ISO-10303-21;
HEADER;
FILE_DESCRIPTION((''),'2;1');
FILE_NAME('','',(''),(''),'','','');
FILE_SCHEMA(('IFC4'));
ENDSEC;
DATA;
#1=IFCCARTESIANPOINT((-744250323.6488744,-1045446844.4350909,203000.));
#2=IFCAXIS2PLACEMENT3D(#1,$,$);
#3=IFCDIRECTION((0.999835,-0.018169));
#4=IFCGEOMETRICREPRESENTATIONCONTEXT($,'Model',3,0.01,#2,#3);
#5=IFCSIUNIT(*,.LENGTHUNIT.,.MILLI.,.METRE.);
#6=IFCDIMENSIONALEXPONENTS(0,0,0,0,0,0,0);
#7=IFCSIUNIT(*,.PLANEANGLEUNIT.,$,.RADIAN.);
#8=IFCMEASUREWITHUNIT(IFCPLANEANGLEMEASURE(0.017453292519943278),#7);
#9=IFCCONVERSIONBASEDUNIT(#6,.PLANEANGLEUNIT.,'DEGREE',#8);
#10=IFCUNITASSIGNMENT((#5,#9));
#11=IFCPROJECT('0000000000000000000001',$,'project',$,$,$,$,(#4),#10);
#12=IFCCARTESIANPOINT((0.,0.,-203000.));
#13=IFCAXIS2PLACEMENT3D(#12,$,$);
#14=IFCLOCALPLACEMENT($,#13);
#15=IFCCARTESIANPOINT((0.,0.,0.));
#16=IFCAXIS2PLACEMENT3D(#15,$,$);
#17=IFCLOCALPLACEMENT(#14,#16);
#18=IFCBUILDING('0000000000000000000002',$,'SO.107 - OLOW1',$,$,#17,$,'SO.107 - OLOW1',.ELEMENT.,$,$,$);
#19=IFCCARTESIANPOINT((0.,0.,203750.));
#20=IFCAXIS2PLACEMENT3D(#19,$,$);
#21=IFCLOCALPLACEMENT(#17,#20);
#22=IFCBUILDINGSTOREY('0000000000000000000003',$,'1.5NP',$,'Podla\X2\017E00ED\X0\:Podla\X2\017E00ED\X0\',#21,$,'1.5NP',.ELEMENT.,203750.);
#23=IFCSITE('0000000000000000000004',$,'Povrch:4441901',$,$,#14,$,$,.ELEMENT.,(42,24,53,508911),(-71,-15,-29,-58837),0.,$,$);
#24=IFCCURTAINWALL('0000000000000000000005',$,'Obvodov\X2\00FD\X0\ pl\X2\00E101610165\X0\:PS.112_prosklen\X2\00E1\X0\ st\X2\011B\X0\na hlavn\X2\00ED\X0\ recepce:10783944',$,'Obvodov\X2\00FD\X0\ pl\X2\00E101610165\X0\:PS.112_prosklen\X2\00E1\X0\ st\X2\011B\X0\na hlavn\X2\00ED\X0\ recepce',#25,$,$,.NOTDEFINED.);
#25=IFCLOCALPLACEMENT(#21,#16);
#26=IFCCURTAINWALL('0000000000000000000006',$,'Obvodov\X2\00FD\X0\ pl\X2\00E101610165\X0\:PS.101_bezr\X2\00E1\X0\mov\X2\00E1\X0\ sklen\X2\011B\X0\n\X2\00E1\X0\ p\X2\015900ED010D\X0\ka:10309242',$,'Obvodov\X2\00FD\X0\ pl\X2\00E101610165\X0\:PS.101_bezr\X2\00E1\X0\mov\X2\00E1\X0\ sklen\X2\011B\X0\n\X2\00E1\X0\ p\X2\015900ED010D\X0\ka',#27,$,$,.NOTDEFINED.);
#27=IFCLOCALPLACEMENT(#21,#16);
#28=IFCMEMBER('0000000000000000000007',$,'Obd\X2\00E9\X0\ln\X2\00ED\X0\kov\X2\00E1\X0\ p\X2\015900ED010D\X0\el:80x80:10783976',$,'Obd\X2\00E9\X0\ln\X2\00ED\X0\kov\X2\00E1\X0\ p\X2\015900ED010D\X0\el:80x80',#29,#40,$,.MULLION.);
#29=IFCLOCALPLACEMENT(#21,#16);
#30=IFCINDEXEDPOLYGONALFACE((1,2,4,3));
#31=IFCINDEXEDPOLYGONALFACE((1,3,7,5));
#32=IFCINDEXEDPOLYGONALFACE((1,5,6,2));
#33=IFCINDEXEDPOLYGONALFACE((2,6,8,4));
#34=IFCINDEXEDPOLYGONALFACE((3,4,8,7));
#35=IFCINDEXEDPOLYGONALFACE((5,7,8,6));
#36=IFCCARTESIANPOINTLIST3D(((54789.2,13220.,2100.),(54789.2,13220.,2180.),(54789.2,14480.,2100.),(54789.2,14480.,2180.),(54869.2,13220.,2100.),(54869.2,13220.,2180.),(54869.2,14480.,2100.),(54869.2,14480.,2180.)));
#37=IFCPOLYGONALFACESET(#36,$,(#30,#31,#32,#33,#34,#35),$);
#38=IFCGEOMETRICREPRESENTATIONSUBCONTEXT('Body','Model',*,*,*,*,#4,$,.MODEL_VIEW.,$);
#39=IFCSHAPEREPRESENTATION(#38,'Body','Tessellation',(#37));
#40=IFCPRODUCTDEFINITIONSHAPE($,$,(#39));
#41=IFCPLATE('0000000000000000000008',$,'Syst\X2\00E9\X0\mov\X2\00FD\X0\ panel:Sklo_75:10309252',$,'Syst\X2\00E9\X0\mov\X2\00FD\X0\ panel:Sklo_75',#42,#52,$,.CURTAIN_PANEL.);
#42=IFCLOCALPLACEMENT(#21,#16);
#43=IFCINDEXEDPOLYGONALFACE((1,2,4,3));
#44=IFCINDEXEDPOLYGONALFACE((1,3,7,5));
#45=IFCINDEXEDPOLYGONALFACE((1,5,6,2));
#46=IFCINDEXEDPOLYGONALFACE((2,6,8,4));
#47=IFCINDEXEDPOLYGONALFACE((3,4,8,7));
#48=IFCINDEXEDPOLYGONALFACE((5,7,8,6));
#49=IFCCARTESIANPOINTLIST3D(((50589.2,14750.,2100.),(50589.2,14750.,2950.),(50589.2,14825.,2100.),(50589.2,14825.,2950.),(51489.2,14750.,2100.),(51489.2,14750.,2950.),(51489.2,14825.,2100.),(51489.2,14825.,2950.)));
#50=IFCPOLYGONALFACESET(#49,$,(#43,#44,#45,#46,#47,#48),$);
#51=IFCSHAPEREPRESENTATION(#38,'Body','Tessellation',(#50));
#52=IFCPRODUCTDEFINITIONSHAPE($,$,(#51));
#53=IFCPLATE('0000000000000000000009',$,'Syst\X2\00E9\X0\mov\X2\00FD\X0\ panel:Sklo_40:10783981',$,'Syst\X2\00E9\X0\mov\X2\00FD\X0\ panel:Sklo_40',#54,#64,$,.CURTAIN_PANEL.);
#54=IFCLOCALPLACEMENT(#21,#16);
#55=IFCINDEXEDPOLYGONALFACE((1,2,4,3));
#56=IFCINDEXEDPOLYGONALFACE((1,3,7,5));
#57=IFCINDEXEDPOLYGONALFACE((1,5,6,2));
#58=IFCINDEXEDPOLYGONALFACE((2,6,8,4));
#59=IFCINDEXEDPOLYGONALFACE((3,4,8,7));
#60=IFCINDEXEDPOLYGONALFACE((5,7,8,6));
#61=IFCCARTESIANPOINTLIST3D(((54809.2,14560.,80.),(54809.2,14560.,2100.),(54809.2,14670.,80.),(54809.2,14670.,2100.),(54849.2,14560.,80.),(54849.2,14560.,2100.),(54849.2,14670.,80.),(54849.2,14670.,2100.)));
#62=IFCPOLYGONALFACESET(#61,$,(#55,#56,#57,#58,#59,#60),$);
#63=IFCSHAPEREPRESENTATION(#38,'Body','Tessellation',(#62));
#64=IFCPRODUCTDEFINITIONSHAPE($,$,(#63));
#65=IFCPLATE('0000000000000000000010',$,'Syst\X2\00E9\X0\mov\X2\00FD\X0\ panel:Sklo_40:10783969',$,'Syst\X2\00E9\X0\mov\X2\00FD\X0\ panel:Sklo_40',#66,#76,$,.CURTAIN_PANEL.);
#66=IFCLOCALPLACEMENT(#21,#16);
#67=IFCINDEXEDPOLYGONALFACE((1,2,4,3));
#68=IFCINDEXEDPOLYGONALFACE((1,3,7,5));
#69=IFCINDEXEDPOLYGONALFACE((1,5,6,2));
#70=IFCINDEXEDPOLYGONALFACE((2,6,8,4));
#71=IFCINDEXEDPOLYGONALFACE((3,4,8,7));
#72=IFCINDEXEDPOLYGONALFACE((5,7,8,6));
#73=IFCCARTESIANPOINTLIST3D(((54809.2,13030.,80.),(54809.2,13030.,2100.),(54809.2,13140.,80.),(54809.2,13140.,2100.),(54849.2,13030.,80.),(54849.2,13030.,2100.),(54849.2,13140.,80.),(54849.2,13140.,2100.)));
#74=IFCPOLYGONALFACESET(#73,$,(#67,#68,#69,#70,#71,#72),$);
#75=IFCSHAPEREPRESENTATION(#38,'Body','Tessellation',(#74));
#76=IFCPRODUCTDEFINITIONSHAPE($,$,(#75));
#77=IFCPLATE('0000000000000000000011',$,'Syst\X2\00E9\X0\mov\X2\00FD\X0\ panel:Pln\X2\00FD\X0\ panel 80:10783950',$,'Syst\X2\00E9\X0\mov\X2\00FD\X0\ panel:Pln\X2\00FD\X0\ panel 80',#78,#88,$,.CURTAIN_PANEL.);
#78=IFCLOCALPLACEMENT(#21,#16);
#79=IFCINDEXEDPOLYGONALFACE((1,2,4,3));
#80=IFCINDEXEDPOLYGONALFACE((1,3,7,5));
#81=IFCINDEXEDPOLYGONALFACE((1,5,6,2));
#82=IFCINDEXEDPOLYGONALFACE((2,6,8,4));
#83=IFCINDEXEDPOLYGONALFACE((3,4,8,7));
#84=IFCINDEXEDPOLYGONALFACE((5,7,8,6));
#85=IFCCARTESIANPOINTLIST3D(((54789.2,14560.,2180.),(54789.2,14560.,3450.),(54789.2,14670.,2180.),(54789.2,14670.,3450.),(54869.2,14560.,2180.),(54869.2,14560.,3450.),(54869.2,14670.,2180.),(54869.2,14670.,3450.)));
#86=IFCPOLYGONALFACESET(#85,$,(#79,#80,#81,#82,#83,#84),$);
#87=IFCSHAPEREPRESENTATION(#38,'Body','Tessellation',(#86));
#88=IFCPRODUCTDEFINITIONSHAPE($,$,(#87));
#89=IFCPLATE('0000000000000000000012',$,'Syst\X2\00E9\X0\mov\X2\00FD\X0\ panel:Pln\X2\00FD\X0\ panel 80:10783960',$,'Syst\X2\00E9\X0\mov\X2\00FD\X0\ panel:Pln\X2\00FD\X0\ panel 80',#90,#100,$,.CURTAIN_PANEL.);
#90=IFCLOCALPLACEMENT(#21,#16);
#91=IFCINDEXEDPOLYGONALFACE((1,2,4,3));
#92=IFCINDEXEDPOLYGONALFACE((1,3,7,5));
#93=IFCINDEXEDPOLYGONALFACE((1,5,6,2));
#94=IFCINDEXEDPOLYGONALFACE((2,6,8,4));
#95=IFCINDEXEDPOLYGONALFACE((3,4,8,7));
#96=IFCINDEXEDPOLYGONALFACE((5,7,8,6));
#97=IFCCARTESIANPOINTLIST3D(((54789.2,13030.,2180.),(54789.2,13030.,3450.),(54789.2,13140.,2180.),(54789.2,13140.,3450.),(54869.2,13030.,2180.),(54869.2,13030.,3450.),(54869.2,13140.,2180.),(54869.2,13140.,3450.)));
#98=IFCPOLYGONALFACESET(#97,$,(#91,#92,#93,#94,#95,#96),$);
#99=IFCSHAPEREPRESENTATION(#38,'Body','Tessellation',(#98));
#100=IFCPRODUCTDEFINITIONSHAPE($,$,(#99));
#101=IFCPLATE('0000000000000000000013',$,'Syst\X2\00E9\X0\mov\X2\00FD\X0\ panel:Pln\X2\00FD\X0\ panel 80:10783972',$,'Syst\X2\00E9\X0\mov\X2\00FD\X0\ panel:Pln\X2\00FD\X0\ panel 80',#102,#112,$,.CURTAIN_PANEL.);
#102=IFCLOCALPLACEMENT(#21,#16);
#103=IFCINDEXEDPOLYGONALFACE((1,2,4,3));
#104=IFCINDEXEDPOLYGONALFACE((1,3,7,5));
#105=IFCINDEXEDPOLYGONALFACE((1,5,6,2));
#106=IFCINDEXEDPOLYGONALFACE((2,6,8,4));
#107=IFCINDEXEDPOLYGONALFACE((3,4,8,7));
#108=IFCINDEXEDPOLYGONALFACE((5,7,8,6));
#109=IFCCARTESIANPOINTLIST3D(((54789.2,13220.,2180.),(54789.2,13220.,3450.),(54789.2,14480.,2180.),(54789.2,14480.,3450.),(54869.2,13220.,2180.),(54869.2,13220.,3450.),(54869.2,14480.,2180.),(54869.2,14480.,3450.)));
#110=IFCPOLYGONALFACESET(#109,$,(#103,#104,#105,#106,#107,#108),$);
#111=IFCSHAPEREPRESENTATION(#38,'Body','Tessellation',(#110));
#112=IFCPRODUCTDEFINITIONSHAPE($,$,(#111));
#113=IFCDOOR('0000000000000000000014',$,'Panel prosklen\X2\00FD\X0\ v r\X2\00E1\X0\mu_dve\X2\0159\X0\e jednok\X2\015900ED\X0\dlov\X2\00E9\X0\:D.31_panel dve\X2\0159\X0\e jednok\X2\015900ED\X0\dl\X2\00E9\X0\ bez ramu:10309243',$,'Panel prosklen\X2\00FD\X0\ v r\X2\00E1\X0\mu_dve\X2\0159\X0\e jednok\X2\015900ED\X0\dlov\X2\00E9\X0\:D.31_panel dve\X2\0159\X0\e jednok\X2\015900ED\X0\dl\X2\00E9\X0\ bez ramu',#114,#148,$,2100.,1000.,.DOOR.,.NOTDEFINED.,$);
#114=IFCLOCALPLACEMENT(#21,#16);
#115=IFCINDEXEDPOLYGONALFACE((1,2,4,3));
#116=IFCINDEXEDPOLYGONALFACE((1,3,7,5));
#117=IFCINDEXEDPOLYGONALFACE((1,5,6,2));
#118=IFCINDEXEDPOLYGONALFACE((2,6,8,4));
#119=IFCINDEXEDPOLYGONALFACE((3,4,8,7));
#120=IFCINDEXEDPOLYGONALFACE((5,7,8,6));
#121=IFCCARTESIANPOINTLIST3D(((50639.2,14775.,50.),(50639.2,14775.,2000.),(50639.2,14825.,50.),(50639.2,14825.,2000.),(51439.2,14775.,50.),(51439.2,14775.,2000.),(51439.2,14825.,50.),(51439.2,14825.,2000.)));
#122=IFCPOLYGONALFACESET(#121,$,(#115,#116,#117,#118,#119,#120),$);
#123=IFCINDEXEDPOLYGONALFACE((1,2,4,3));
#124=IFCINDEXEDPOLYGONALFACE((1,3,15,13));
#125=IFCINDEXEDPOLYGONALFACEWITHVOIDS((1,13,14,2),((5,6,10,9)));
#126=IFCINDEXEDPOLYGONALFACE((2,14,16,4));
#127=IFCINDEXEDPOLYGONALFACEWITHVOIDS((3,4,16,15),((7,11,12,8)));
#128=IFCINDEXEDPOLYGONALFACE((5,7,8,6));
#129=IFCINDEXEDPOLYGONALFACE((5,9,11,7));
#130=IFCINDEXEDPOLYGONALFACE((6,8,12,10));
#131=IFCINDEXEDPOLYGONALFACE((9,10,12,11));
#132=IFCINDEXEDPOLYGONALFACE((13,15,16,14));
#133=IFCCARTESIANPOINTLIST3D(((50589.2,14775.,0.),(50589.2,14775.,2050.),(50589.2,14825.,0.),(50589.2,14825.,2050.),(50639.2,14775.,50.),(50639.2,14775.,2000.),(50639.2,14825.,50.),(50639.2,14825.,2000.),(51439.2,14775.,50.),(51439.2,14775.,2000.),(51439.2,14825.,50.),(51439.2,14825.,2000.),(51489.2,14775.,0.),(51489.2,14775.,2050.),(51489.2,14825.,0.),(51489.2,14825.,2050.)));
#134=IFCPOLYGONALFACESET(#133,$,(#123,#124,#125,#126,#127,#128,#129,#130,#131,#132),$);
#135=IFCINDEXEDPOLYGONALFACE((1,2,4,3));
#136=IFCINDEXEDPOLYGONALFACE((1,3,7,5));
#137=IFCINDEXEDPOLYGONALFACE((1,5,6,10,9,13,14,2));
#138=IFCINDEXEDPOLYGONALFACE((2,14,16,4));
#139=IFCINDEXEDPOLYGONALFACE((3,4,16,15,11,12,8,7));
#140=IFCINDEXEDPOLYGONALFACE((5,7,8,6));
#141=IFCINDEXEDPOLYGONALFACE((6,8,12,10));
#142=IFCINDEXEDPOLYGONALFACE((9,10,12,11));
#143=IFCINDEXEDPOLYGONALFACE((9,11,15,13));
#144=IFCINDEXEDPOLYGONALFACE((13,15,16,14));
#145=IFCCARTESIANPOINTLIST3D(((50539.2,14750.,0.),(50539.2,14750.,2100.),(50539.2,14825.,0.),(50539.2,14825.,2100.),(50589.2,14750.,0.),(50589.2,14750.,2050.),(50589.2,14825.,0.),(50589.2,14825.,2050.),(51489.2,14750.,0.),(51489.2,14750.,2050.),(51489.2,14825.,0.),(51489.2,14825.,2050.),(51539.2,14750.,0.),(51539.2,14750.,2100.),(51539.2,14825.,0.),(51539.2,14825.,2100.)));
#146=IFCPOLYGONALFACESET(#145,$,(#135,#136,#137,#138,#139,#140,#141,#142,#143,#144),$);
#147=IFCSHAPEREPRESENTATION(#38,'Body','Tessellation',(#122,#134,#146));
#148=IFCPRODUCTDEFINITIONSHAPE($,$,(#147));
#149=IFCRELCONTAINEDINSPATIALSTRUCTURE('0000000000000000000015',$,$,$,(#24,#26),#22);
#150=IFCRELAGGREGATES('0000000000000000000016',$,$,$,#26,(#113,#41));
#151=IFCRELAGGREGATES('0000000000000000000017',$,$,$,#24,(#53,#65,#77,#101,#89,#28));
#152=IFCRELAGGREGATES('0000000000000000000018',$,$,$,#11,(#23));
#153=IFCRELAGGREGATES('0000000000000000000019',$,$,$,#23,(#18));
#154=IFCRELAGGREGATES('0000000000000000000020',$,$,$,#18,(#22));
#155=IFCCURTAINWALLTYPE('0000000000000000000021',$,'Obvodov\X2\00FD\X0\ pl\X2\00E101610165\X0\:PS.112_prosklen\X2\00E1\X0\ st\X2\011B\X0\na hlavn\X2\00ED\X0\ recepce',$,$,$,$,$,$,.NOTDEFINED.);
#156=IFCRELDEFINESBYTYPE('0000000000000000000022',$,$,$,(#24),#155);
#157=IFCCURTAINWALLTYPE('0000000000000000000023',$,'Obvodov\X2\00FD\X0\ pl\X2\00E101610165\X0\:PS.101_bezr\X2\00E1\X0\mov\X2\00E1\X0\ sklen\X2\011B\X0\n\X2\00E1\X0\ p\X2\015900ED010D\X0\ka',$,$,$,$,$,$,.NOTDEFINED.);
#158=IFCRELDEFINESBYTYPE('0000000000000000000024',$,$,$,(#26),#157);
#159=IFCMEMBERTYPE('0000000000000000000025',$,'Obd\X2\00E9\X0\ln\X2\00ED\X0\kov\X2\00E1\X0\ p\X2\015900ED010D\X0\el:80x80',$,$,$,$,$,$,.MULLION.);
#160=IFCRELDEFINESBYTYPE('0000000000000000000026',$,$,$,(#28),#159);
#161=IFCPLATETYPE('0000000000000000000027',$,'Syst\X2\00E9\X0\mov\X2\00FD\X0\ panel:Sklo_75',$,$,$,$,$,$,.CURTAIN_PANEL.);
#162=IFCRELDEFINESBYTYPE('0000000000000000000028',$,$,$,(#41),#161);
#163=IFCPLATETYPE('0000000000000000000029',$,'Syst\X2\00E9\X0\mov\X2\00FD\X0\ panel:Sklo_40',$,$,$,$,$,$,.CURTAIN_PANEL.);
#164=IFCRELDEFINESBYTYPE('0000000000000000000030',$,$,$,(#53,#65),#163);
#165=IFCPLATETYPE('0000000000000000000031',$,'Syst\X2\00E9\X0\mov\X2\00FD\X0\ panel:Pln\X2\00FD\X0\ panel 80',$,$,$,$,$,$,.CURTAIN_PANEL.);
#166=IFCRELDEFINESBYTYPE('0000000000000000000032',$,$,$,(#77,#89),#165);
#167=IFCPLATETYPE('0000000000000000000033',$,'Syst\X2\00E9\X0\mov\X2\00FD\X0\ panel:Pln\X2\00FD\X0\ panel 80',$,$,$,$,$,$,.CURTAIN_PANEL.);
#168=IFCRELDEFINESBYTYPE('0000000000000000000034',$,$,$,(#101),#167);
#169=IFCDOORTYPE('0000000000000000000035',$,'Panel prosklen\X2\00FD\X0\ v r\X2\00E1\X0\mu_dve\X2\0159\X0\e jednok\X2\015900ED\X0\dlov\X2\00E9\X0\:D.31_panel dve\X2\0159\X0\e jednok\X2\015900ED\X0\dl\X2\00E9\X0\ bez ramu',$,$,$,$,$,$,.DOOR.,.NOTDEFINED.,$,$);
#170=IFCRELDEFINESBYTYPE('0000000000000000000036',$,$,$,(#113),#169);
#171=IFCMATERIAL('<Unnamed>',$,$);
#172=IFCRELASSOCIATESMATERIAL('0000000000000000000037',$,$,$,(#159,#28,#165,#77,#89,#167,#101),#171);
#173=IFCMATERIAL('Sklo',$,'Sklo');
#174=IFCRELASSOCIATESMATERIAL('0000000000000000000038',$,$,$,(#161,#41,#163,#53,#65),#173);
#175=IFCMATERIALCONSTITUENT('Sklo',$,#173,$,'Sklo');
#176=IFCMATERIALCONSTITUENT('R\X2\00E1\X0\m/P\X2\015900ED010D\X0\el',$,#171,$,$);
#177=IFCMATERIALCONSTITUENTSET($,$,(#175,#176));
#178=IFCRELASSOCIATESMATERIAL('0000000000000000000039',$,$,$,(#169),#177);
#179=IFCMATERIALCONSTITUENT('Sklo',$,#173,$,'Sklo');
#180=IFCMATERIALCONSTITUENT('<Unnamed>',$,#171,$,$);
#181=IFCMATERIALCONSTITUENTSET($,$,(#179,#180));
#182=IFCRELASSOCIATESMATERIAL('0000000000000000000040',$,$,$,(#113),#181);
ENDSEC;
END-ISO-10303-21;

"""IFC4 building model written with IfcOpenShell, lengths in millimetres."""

from ifc_helpers import new_model, entity, si_unit, converted_unit, direction, frame, origin, place, context, subcontext, project, spatial, indexed_curve, outline, extrude, source, transform, mapped, material, constituent, constituent_set, type_object, type_shapes, element, aggregate, save


model = new_model("IFC4")

# Units and contexts
model_context = context("Model", 3, precision=0.01, world=frame((-744250323.6488744, -1045446844.4350909, 203000.0)), true_north=direction((0.999835, -0.018169)))
body_context = subcontext(model_context, "Body", "Model", "MODEL_VIEW")
ifc_project = project(units=[si_unit("LENGTHUNIT", "METRE", prefix="MILLI"), converted_unit("PLANEANGLEUNIT", "DEGREE", entity("IfcPlaneAngleMeasure", 0.017453292519943278), si_unit("PLANEANGLEUNIT", "RADIAN"), dimensions=[0, 0, 0, 0, 0, 0, 0])], contexts=[model_context])

# Site, building, storey
site_placement = place(None, frame((0.0, 0.0, -203000.0)))
site = spatial("IfcSite", under=ifc_project, at=site_placement, Name="Povrch:4441901", CompositionType="ELEMENT", RefLatitude=(42, 24, 53, 508911), RefLongitude=(-71, -15, -29, -58837), RefElevation=0.0)
building_placement = place(site_placement, origin())
building = spatial("IfcBuilding", under=site, at=building_placement, Name="SO.107 - OLOW1", LongName="SO.107 - OLOW1", CompositionType="ELEMENT")
storey_placement = place(building_placement, frame((0.0, 0.0, 203750.0)))
storey = spatial("IfcBuildingStorey", under=building, at=storey_placement, Name="1.5NP", ObjectType="Podlaží:Podlaží", LongName="1.5NP", CompositionType="ELEMENT", Elevation=203750.0)

# Curtain walls
curtain_wall_type_1 = type_object("IfcCurtainWallType", Name="Obvodový plášť:PS.112_prosklená stěna hlavní recepce", PredefinedType="NOTDEFINED")
curtain_wall_1_placement = place(storey_placement, frame((0.0, 0.0, -203750.0)))
curtain_wall_1 = element("IfcCurtainWall", 1, at=curtain_wall_1_placement, inside=storey, type_object=curtain_wall_type_1, Name="Obvodový plášť:PS.112_prosklená stěna hlavní recepce:10783944", ObjectType="Obvodový plášť:PS.112_prosklená stěna hlavní recepce", PredefinedType="NOTDEFINED")
ifc_material_1 = material(Name="<Unnamed>")
curtain_wall_type_2 = type_object("IfcCurtainWallType", Name="Obvodový plášť:PS.101_bezrámová skleněná příčka", PredefinedType="NOTDEFINED")
curtain_wall_2_placement = place(storey_placement, frame((0.0, 0.0, -203750.0)))
curtain_wall_2 = element("IfcCurtainWall", 2, at=curtain_wall_2_placement, inside=storey, type_object=curtain_wall_type_2, Name="Obvodový plášť:PS.101_bezrámová skleněná příčka:10309242", ObjectType="Obvodový plášť:PS.101_bezrámová skleněná příčka", PredefinedType="NOTDEFINED")

# Member
member_type_1 = type_object("IfcMemberType", Name="Obdélníková příčel:80x80", PredefinedType="MULLION", material=ifc_material_1)
shared_shape_1 = source(origin(), body_context, "Body", "SweptSolid", [
    extrude(outline(indexed_curve([(-40.0, -40.0), (40.0, -40.0), (40.0, 40.0), (-40.0, 40.0), (-40.0, -40.0)], self_intersect=False)), frame((0.0, 0.0, -1260.0), z_axis=(0.0, 0.0, 1.0), x_axis=(-1.0, 0.0, 0.0)), (0.0, 0.0, 1.0), 1260.0),
])
type_shapes(member_type_1, [shared_shape_1])
member_1_placement = place(curtain_wall_1_placement, frame((54829.2, 13220.0, 205890.0), z_axis=(0.0, -1.0, 0.0), x_axis=(0.0, 0.0, 1.0)))
member_1 = element("IfcMember", 3, at=member_1_placement, type_object=member_type_1, material=ifc_material_1, Name="Obdélníková příčel:80x80:10783976", ObjectType="Obdélníková příčel:80x80", PredefinedType="MULLION", context=body_context, shape_type="MappedRepresentation", body=[
    mapped(shared_shape_1, transform((0.0, 0.0, 0.0), scale=1.0)),
])

# Plates
ifc_material_2 = material(Name="Sklo", Category="Sklo")
plate_type_1 = type_object("IfcPlateType", Name="Systémový panel:Sklo_75", PredefinedType="CURTAIN_PANEL", material=ifc_material_2)
shared_shape_2 = source(origin(), body_context, "Body", "SweptSolid", [
    extrude(outline(indexed_curve([(-37.5, -450.0), (37.5, -450.0), (37.5, 450.0), (-37.5, 450.0), (-37.5, -450.0)], self_intersect=False)), frame((0.0, 37.5, 0.0), z_axis=(0.0, 0.0, 1.0), x_axis=(0.0, 1.0, 0.0)), (0.0, 0.0, 1.0), 850.0),
])
type_shapes(plate_type_1, [shared_shape_2])
plate_1_placement = place(curtain_wall_2_placement, frame((51039.2, 14750.0, 205850.0)))
plate_1 = element("IfcPlate", 4, at=plate_1_placement, type_object=plate_type_1, material=ifc_material_2, Name="Systémový panel:Sklo_75:10309252", ObjectType="Systémový panel:Sklo_75", PredefinedType="CURTAIN_PANEL", context=body_context, shape_type="MappedRepresentation", body=[
    mapped(shared_shape_2, transform((0.0, 0.0, 0.0), scale=1.0)),
])
plate_type_2 = type_object("IfcPlateType", Name="Systémový panel:Sklo_40", PredefinedType="CURTAIN_PANEL", material=ifc_material_2)
shared_shape_3 = source(origin(), body_context, "Body", "SweptSolid", [
    extrude(outline(indexed_curve([(-20.0, -55.0), (20.0, -55.0), (20.0, 55.0), (-20.0, 55.0), (-20.0, -55.0)], self_intersect=False)), frame((0.0, 0.0, 0.0), z_axis=(0.0, 0.0, 1.0), x_axis=(0.0, 1.0, 0.0)), (0.0, 0.0, 1.0), 2020.0),
])
type_shapes(plate_type_2, [shared_shape_3])
plate_2_placement = place(curtain_wall_1_placement, frame((54829.2, 14615.0, 203830.0), z_axis=(0.0, 0.0, 1.0), x_axis=(0.0, -1.0, 0.0)))
plate_2 = element("IfcPlate", 5, at=plate_2_placement, type_object=plate_type_2, material=ifc_material_2, Name="Systémový panel:Sklo_40:10783981", ObjectType="Systémový panel:Sklo_40", PredefinedType="CURTAIN_PANEL", context=body_context, shape_type="MappedRepresentation", body=[
    mapped(shared_shape_3, transform((0.0, 0.0, 0.0), scale=1.0)),
])
plate_3_placement = place(curtain_wall_1_placement, frame((54829.2, 13085.0, 203830.0), z_axis=(0.0, 0.0, 1.0), x_axis=(0.0, -1.0, 0.0)))
plate_3 = element("IfcPlate", 6, at=plate_3_placement, type_object=plate_type_2, material=ifc_material_2, Name="Systémový panel:Sklo_40:10783969", ObjectType="Systémový panel:Sklo_40", PredefinedType="CURTAIN_PANEL", context=body_context, shape_type="MappedRepresentation", body=[
    mapped(shared_shape_3, transform((0.0, 0.0, 0.0), scale=1.0)),
])
plate_type_3 = type_object("IfcPlateType", Name="Systémový panel:Plný panel 80", PredefinedType="CURTAIN_PANEL", material=ifc_material_1)
shared_shape_4 = source(origin(), body_context, "Body", "SweptSolid", [
    extrude(outline(indexed_curve([(-40.0, -55.0), (40.0, -55.0), (40.0, 55.0), (-40.0, 55.0), (-40.0, -55.0)], self_intersect=False)), frame((0.0, 0.0, 0.0), z_axis=(0.0, 0.0, 1.0), x_axis=(0.0, 1.0, 0.0)), (0.0, 0.0, 1.0), 1270.0),
])
type_shapes(plate_type_3, [shared_shape_4])
plate_4_placement = place(curtain_wall_1_placement, frame((54829.2, 14615.0, 205930.0), z_axis=(0.0, 0.0, 1.0), x_axis=(0.0, -1.0, 0.0)))
plate_4 = element("IfcPlate", 7, at=plate_4_placement, type_object=plate_type_3, material=ifc_material_1, Name="Systémový panel:Plný panel 80:10783950", ObjectType="Systémový panel:Plný panel 80", PredefinedType="CURTAIN_PANEL", context=body_context, shape_type="MappedRepresentation", body=[
    mapped(shared_shape_4, transform((0.0, 0.0, 0.0), scale=1.0)),
])
plate_5_placement = place(curtain_wall_1_placement, frame((54829.2, 13085.0, 205930.0), z_axis=(0.0, 0.0, 1.0), x_axis=(0.0, -1.0, 0.0)))
plate_5 = element("IfcPlate", 8, at=plate_5_placement, type_object=plate_type_3, material=ifc_material_1, Name="Systémový panel:Plný panel 80:10783960", ObjectType="Systémový panel:Plný panel 80", PredefinedType="CURTAIN_PANEL", context=body_context, shape_type="MappedRepresentation", body=[
    mapped(shared_shape_4, transform((0.0, 0.0, 0.0), scale=1.0)),
])
plate_type_4 = type_object("IfcPlateType", Name="Systémový panel:Plný panel 80", PredefinedType="CURTAIN_PANEL", material=ifc_material_1)
shared_shape_5 = source(origin(), body_context, "Body", "SweptSolid", [
    extrude(outline(indexed_curve([(-40.0, -630.0), (40.0, -630.0), (40.0, 630.0), (-40.0, 630.0), (-40.0, -630.0)], self_intersect=False)), frame((0.0, 0.0, 0.0), z_axis=(0.0, 0.0, 1.0), x_axis=(0.0, 1.0, 0.0)), (0.0, 0.0, 1.0), 1270.0),
])
type_shapes(plate_type_4, [shared_shape_5])
plate_6_placement = place(curtain_wall_1_placement, frame((54829.2, 13850.0, 205930.0), z_axis=(0.0, 0.0, 1.0), x_axis=(0.0, -1.0, 0.0)))
plate_6 = element("IfcPlate", 9, at=plate_6_placement, type_object=plate_type_4, material=ifc_material_1, Name="Systémový panel:Plný panel 80:10783972", ObjectType="Systémový panel:Plný panel 80", PredefinedType="CURTAIN_PANEL", context=body_context, shape_type="MappedRepresentation", body=[
    mapped(shared_shape_5, transform((0.0, 0.0, 0.0), scale=1.0)),
])

# Door
ifc_constituent_1 = constituent(ifc_material_2, Name="Sklo", Category="Sklo")
ifc_constituent_2 = constituent(ifc_material_1, Name="<Unnamed>")
ifc_constituent_set_1 = constituent_set(constituents=[ifc_constituent_1, ifc_constituent_2])
ifc_constituent_3 = constituent(ifc_material_2, Name="Sklo", Category="Sklo")
ifc_constituent_4 = constituent(ifc_material_1, Name="Rám/Příčel")
ifc_constituent_set_2 = constituent_set(constituents=[ifc_constituent_3, ifc_constituent_4])
door_type_1 = type_object("IfcDoorType", Name="Panel prosklený v rámu_dveře jednokřídlové:D.31_panel dveře jednokřídlé bez ramu", OperationType="NOTDEFINED", PredefinedType="DOOR", material=ifc_constituent_set_2)
shared_shape_6 = source(origin(), body_context, "Body", "SweptSolid", [
    extrude(outline(indexed_curve([(-25.0, -400.0), (25.0, -400.0), (25.0, 400.0), (-25.0, 400.0), (-25.0, -400.0)], self_intersect=False)), frame((0.0, -50.0, 50.0), z_axis=(0.0, 0.0, 1.0), x_axis=(0.0, -1.0, 0.0)), (0.0, 0.0, 1.0), 1950.0),
    extrude(outline(indexed_curve([(-1025.0, -450.0), (1025.0, -450.0), (1025.0, 450.0), (-1025.0, 450.0), (-1025.0, -450.0)], self_intersect=False), holes=[indexed_curve([(-975.0, -400.0), (-975.0, 400.0), (975.0, 400.0), (975.0, -400.0), (-975.0, -400.0)], self_intersect=False)]), frame((0.0, -25.0, 1025.0), z_axis=(0.0, -1.0, 0.0), x_axis=(0.0, 0.0, -1.0)), (0.0, 0.0, 1.0), 50.0),
    extrude(outline(indexed_curve([(-1062.5, -500.0), (1037.5, -500.0), (1037.5, -450.0), (-1012.5, -450.0), (-1012.5, 450.0), (1037.5, 450.0), (1037.5, 500.0), (-1062.5, 500.0), (-1062.5, -500.0)], self_intersect=False)), frame((0.0, 0.0, 1037.5), z_axis=(0.0, -1.0, 0.0), x_axis=(0.0, 0.0, -1.0)), (0.0, 0.0, 1.0), 75.0),
])
type_shapes(door_type_1, [shared_shape_6])
door_1_placement = place(curtain_wall_2_placement, frame((51039.2, 14750.0, 203750.0), z_axis=(0.0, 0.0, 1.0), x_axis=(-1.0, 0.0, 0.0)))
door_1 = element("IfcDoor", 10, at=door_1_placement, type_object=door_type_1, material=ifc_constituent_set_1, Name="Panel prosklený v rámu_dveře jednokřídlové:D.31_panel dveře jednokřídlé bez ramu:10309243", ObjectType="Panel prosklený v rámu_dveře jednokřídlové:D.31_panel dveře jednokřídlé bez ramu", OperationType="NOTDEFINED", OverallHeight=2100.0, OverallWidth=1000.0, PredefinedType="DOOR", context=body_context, shape_type="MappedRepresentation", body=[
    mapped(shared_shape_6, transform((0.0, 0.0, 0.0), scale=1.0)),
])
aggregate(curtain_wall_2, [door_1, plate_1])
aggregate(curtain_wall_1, [plate_2, plate_3, plate_4, plate_6, plate_5, member_1])

save(model, "model.ifc")
